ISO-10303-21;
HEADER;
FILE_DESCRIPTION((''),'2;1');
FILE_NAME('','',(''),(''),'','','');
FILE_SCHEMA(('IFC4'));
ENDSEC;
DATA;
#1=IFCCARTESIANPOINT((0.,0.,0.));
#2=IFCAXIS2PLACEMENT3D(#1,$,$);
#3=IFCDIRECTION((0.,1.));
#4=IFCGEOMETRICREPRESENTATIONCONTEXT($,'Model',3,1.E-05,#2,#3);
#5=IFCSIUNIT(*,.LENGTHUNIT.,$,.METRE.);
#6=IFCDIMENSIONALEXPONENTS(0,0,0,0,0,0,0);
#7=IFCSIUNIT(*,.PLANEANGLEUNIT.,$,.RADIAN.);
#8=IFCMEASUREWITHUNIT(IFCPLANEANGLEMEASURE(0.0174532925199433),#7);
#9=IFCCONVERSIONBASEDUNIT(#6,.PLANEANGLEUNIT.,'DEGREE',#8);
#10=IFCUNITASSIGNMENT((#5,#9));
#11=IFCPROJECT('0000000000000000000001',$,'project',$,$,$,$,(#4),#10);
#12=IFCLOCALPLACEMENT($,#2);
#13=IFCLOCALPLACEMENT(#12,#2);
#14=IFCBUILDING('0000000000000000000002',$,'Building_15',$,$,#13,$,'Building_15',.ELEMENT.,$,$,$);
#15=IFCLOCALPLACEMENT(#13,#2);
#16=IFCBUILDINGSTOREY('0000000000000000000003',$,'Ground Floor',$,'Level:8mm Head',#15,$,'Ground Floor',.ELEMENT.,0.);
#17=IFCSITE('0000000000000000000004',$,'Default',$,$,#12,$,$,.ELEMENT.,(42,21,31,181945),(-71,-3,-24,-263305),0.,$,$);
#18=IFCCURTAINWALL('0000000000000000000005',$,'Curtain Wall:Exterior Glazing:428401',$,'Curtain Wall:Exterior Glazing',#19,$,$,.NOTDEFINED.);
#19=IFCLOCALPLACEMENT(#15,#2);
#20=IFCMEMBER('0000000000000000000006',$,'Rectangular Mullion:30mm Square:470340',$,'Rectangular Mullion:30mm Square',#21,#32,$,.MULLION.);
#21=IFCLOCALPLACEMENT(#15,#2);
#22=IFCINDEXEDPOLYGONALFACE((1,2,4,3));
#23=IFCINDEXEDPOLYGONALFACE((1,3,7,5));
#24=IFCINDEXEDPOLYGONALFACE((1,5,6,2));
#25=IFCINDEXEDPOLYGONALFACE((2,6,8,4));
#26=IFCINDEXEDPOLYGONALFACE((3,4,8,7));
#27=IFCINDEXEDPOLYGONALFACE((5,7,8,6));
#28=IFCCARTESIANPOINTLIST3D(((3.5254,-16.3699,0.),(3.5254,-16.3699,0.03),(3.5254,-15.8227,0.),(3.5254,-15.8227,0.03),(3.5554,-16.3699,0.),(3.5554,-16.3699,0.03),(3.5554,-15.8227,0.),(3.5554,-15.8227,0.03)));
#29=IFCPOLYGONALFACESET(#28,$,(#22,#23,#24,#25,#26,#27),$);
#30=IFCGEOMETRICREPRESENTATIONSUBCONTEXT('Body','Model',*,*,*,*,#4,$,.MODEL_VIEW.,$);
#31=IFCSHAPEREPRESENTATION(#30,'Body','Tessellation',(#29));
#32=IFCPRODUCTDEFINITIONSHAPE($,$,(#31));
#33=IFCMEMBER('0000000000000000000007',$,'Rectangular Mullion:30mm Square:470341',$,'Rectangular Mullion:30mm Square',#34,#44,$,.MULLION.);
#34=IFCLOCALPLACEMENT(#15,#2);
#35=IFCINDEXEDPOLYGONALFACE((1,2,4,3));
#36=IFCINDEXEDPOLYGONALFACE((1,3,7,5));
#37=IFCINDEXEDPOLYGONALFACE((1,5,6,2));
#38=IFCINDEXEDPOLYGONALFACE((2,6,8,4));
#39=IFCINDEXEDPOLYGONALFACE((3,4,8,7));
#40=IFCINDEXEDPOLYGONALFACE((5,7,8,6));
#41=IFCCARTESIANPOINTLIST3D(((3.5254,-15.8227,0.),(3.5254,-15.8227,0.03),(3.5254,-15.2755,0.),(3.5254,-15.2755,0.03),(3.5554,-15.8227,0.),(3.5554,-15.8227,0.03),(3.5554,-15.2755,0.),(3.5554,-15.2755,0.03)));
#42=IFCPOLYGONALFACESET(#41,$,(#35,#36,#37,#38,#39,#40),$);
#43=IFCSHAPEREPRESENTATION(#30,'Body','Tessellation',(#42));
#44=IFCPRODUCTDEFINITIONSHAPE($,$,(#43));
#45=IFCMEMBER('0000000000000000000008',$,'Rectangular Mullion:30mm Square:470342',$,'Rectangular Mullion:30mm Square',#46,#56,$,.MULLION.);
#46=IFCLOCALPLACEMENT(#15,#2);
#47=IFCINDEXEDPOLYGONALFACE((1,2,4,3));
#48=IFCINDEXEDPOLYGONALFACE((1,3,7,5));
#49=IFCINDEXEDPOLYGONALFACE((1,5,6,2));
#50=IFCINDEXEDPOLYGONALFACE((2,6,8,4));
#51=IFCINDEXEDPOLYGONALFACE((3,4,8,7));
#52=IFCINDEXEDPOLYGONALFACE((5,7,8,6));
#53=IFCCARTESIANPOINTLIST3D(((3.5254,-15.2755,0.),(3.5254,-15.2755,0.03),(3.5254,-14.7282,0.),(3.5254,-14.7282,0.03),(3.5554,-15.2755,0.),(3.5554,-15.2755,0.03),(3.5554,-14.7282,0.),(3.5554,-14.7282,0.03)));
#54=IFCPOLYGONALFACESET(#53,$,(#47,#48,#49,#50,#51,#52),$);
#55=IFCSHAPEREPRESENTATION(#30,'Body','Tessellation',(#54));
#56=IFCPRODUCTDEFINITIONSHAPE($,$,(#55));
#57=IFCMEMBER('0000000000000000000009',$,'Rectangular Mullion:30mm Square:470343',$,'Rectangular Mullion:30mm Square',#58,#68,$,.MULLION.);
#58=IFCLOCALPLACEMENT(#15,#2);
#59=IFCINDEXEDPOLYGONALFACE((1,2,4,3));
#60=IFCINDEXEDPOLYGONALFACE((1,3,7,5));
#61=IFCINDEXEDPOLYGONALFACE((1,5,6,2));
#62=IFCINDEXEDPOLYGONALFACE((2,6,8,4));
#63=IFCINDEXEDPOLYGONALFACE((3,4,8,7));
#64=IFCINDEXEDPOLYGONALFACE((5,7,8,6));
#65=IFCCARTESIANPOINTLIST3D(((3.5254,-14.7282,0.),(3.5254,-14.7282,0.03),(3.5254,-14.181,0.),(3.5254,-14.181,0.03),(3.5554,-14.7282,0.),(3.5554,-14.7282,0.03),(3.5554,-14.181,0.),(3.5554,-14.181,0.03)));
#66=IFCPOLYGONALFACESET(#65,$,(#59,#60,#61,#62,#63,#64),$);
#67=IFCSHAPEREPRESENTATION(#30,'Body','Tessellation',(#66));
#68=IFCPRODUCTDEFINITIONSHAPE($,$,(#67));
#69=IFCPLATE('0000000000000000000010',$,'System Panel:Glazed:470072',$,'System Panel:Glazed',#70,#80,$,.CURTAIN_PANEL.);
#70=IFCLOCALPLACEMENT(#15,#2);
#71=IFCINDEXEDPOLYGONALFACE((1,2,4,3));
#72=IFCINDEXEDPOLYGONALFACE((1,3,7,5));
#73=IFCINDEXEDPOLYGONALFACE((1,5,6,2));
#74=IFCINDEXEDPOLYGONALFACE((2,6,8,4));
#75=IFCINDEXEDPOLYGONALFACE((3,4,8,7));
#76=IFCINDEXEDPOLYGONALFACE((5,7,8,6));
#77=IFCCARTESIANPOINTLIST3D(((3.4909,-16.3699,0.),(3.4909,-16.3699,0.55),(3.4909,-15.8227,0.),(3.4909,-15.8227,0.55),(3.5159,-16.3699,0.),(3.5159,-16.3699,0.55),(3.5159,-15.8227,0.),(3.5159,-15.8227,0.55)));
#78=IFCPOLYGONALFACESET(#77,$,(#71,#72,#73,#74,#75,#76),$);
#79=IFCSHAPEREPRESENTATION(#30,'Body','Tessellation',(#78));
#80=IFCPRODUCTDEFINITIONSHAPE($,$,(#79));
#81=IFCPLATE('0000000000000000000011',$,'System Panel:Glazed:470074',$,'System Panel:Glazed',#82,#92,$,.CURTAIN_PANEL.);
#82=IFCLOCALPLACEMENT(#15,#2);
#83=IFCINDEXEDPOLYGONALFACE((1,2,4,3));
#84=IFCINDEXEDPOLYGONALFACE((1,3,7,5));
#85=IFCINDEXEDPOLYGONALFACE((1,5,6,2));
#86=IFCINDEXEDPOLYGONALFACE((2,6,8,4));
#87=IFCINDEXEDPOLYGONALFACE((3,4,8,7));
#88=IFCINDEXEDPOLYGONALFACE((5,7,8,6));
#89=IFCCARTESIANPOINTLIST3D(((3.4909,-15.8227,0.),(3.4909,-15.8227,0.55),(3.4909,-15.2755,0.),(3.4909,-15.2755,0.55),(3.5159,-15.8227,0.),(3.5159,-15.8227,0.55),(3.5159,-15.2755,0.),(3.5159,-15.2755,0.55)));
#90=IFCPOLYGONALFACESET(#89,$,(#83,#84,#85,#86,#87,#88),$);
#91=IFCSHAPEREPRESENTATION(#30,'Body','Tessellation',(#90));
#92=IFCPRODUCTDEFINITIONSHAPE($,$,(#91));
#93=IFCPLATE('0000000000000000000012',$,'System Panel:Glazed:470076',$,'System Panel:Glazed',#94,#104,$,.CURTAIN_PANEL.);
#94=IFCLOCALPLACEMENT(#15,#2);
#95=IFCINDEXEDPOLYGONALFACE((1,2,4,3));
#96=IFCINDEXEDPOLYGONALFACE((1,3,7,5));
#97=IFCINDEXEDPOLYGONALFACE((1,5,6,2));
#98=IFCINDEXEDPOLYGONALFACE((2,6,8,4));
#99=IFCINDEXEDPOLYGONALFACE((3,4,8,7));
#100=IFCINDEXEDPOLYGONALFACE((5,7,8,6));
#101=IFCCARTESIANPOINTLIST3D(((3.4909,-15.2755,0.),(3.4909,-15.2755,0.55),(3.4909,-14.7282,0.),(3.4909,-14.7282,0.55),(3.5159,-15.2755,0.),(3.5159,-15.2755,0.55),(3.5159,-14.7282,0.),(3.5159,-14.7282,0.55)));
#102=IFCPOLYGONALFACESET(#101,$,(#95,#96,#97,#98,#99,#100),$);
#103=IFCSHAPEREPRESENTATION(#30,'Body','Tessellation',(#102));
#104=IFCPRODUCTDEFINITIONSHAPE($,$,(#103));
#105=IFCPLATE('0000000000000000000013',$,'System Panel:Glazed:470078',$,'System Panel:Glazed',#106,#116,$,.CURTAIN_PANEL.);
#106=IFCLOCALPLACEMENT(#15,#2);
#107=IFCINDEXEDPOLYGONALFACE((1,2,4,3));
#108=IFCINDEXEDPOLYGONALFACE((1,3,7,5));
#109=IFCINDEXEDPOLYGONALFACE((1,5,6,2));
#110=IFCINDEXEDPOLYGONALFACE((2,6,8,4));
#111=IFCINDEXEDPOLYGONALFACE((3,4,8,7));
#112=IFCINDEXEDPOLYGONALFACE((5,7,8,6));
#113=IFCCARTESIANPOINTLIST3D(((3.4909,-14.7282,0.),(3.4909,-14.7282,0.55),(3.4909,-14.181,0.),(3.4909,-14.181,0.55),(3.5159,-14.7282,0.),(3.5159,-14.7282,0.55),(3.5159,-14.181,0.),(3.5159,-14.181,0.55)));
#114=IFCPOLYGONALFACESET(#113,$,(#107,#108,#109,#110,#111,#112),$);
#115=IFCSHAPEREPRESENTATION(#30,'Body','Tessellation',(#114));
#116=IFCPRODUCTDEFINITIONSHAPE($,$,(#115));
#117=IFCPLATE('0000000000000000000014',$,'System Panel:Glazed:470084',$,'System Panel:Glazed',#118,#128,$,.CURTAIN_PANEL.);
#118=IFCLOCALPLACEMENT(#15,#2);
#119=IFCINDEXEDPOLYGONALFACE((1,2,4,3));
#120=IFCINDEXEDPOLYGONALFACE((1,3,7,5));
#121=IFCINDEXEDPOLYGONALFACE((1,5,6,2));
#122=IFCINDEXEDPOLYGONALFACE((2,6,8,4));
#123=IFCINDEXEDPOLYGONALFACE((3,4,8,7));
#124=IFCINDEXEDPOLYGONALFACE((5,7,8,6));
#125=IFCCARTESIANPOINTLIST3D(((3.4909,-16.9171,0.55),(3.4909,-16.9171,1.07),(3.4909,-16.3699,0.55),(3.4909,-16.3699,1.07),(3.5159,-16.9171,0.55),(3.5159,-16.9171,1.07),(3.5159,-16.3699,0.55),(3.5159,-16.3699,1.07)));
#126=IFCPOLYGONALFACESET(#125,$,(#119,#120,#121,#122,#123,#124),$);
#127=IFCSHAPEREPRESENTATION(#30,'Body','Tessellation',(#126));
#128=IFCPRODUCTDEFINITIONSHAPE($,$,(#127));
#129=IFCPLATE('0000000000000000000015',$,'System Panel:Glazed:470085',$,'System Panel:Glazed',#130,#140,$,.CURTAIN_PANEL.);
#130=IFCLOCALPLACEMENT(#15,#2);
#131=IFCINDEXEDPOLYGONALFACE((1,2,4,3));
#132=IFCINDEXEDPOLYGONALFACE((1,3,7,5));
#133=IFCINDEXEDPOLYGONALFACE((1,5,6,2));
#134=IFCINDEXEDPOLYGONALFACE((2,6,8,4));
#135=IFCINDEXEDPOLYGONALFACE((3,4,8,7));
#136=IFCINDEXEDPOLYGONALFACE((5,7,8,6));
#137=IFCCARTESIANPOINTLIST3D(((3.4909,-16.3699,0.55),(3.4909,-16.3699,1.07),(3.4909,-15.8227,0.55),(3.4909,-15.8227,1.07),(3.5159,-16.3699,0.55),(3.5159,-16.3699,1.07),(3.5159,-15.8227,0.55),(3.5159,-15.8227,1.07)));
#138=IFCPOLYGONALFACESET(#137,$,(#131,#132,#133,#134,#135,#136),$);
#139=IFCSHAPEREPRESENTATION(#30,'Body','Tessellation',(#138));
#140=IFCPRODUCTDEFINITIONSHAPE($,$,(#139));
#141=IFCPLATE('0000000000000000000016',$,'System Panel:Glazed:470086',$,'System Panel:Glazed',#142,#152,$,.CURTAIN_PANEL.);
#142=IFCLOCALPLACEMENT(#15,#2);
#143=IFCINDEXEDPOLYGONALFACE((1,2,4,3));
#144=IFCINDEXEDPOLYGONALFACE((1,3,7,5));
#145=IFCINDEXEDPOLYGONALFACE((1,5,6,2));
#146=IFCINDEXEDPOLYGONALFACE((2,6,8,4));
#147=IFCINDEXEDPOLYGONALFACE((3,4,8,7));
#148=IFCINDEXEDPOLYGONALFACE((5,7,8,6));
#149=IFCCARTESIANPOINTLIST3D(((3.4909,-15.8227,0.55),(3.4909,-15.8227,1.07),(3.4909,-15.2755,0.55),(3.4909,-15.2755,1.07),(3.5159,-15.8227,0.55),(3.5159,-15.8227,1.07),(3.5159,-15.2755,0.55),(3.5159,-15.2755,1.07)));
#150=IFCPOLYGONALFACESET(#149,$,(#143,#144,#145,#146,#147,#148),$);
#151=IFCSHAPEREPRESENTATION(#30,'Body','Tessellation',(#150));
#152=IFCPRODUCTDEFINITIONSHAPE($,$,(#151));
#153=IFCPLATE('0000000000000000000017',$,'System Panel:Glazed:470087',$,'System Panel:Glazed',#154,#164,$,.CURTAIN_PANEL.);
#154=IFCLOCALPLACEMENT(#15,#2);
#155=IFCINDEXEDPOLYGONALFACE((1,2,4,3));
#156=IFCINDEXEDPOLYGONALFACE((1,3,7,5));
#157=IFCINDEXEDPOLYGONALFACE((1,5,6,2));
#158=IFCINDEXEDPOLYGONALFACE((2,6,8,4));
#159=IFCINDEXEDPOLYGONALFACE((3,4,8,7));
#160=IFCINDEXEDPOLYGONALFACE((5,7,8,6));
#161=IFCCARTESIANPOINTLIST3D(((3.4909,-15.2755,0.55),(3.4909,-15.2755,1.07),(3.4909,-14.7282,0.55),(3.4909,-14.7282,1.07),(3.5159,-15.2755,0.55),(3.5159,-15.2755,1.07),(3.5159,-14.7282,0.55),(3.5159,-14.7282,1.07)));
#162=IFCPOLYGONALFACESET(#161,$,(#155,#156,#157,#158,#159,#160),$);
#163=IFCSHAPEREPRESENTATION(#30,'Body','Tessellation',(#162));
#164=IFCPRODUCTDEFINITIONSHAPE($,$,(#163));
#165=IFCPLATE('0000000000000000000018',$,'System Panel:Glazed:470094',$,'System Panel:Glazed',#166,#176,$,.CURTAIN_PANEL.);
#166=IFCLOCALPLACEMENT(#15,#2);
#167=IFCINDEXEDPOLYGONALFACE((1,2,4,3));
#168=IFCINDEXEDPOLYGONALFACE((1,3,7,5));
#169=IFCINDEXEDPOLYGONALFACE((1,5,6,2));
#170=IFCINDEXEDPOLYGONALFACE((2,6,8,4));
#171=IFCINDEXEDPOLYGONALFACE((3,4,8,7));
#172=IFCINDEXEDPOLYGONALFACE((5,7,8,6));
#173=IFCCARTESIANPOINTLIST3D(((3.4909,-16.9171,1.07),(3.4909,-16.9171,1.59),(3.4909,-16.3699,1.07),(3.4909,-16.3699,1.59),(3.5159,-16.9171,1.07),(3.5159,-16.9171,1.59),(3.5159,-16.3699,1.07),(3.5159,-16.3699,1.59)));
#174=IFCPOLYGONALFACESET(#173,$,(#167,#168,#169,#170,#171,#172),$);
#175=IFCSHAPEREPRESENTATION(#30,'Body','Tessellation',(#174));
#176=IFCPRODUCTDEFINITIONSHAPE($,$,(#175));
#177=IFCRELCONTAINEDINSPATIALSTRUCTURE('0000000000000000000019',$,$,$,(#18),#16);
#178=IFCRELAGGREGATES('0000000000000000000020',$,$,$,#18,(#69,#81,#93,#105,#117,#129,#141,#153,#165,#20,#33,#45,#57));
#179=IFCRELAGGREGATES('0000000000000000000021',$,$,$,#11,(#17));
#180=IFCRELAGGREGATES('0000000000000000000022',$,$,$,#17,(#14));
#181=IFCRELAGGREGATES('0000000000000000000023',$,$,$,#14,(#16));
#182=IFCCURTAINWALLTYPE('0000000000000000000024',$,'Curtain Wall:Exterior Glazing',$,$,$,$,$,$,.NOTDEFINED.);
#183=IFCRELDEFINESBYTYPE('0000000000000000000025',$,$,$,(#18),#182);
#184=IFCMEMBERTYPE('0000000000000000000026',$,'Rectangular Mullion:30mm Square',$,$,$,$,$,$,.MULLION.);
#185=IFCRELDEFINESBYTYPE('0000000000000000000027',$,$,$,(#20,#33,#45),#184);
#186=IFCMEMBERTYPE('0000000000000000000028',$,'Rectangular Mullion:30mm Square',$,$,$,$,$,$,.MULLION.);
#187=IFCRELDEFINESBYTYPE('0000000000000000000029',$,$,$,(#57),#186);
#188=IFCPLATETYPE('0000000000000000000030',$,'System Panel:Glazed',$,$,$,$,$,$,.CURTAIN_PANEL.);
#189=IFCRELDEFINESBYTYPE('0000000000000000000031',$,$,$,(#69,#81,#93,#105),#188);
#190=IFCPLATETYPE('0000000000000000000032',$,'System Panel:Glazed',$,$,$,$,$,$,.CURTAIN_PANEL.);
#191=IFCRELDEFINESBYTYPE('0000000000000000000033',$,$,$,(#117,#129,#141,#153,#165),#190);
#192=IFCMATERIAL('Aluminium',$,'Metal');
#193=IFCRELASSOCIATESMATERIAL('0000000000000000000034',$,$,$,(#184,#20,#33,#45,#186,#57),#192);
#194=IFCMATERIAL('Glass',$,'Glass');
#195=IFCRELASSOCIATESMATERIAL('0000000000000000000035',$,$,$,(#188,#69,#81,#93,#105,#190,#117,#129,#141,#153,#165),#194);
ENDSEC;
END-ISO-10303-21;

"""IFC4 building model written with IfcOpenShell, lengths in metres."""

from ifc_helpers import new_model, entity, si_unit, converted_unit, direction, frame, origin, place, context, subcontext, project, spatial, indexed_curve, outline, extrude, source, transform, mapped, material, type_object, type_shapes, element, aggregate, save


model = new_model("IFC4")

# Units and contexts
model_context = context("Model", 3, precision=1e-05, world=origin(), true_north=direction((0.0, 1.0)))
body_context = subcontext(model_context, "Body", "Model", "MODEL_VIEW")
ifc_project = project(units=[si_unit("LENGTHUNIT", "METRE"), converted_unit("PLANEANGLEUNIT", "DEGREE", entity("IfcPlaneAngleMeasure", 0.0174532925199433), si_unit("PLANEANGLEUNIT", "RADIAN"), dimensions=[0, 0, 0, 0, 0, 0, 0])], contexts=[model_context])

# Site, building, storey
site_placement = place(None, origin())
site = spatial("IfcSite", under=ifc_project, at=site_placement, Name="Default", CompositionType="ELEMENT", RefLatitude=(42, 21, 31, 181945), RefLongitude=(-71, -3, -24, -263305), RefElevation=0.0)
building_placement = place(site_placement, origin())
building = spatial("IfcBuilding", under=site, at=building_placement, Name="Building_15", LongName="Building_15", CompositionType="ELEMENT")
storey_placement = place(building_placement, origin())
storey = spatial("IfcBuildingStorey", under=building, at=storey_placement, Name="Ground Floor", ObjectType="Level:8mm Head", LongName="Ground Floor", CompositionType="ELEMENT", Elevation=0.0)

# Curtain wall, members, plates
curtain_wall_type = type_object("IfcCurtainWallType", Name="Curtain Wall:Exterior Glazing", PredefinedType="NOTDEFINED")
curtain_wall_placement = place(storey_placement, origin())
curtain_wall = element("IfcCurtainWall", 1, at=curtain_wall_placement, inside=storey, type_object=curtain_wall_type, Name="Curtain Wall:Exterior Glazing:428401", ObjectType="Curtain Wall:Exterior Glazing", PredefinedType="NOTDEFINED")
ifc_material_1 = material(Name="Aluminium", Category="Metal")
member_type_1 = type_object("IfcMemberType", Name="Rectangular Mullion:30mm Square", PredefinedType="MULLION", material=ifc_material_1)
shared_shape_1 = source(origin(), body_context, "Body", "SweptSolid", [
    extrude(outline(indexed_curve([(-0.015, -0.015), (0.015, -0.015), (0.015, 0.015), (-0.015, 0.015), (-0.015, -0.015)], self_intersect=False)), frame((-0.015, 0.0, -0.5472), z_axis=(0.0, 0.0, 1.0), x_axis=(-1.0, 0.0, 0.0)), (0.0, 0.0, 1.0), 0.5472),
])
type_shapes(member_type_1, [shared_shape_1])
member_1_placement = place(curtain_wall_placement, frame((3.5404, -16.3699, 0.0), z_axis=(0.0, -1.0, 0.0), x_axis=(0.0, 0.0, -1.0)))
member_1 = element("IfcMember", 2, at=member_1_placement, type_object=member_type_1, material=ifc_material_1, Name="Rectangular Mullion:30mm Square:470340", ObjectType="Rectangular Mullion:30mm Square", PredefinedType="MULLION", context=body_context, shape_type="MappedRepresentation", body=[
    mapped(shared_shape_1, transform((0.0, 0.0, 0.0), scale=1.0)),
])
member_2_placement = place(curtain_wall_placement, frame((3.5404, -15.8227, 0.0), z_axis=(0.0, -1.0, 0.0), x_axis=(0.0, 0.0, -1.0)))
member_2 = element("IfcMember", 3, at=member_2_placement, type_object=member_type_1, material=ifc_material_1, Name="Rectangular Mullion:30mm Square:470341", ObjectType="Rectangular Mullion:30mm Square", PredefinedType="MULLION", context=body_context, shape_type="MappedRepresentation", body=[
    mapped(shared_shape_1, transform((0.0, 0.0, 0.0), scale=1.0)),
])
member_3_placement = place(curtain_wall_placement, frame((3.5404, -15.2755, 0.0), z_axis=(0.0, -1.0, 0.0), x_axis=(0.0, 0.0, -1.0)))
member_3 = element("IfcMember", 4, at=member_3_placement, type_object=member_type_1, material=ifc_material_1, Name="Rectangular Mullion:30mm Square:470342", ObjectType="Rectangular Mullion:30mm Square", PredefinedType="MULLION", context=body_context, shape_type="MappedRepresentation", body=[
    mapped(shared_shape_1, transform((0.0, 0.0, 0.0), scale=1.0)),
])
member_type_2 = type_object("IfcMemberType", Name="Rectangular Mullion:30mm Square", PredefinedType="MULLION", material=ifc_material_1)
shared_shape_2 = source(origin(), body_context, "Body", "SweptSolid", [
    extrude(outline(indexed_curve([(-0.015, -0.015), (0.015, -0.015), (0.015, 0.015), (-0.015, 0.015), (-0.015, -0.015)], self_intersect=False)), frame((-0.015, 0.0, -0.5472), z_axis=(0.0, 0.0, 1.0), x_axis=(-1.0, 0.0, 0.0)), (0.0, 0.0, 1.0), 0.5472),
])
type_shapes(member_type_2, [shared_shape_2])
member_4_placement = place(curtain_wall_placement, frame((3.5404, -14.7282, 0.0), z_axis=(0.0, -1.0, 0.0), x_axis=(0.0, 0.0, -1.0)))
member_4 = element("IfcMember", 5, at=member_4_placement, type_object=member_type_2, material=ifc_material_1, Name="Rectangular Mullion:30mm Square:470343", ObjectType="Rectangular Mullion:30mm Square", PredefinedType="MULLION", context=body_context, shape_type="MappedRepresentation", body=[
    mapped(shared_shape_2, transform((0.0, 0.0, 0.0), scale=1.0)),
])
ifc_material_2 = material(Name="Glass", Category="Glass")
plate_type_1 = type_object("IfcPlateType", Name="System Panel:Glazed", PredefinedType="CURTAIN_PANEL", material=ifc_material_2)
shared_shape_3 = source(origin(), body_context, "Body", "SweptSolid", [
    extrude(outline(indexed_curve([(-0.0125, -0.2736), (0.0125, -0.2736), (0.0125, 0.2736), (-0.0125, 0.2736), (-0.0125, -0.2736)], self_intersect=False)), frame((0.0, 0.037, 0.0), z_axis=(0.0, 0.0, 1.0), x_axis=(0.0, 1.0, 0.0)), (0.0, 0.0, 1.0), 0.55),
])
type_shapes(plate_type_1, [shared_shape_3])
plate_1_placement = place(curtain_wall_placement, frame((3.5404, -16.0963, 0.0), z_axis=(0.0, 0.0, 1.0), x_axis=(0.0, 1.0, 0.0)))
plate_1 = element("IfcPlate", 6, at=plate_1_placement, type_object=plate_type_1, material=ifc_material_2, Name="System Panel:Glazed:470072", ObjectType="System Panel:Glazed", PredefinedType="CURTAIN_PANEL", context=body_context, shape_type="MappedRepresentation", body=[
    mapped(shared_shape_3, transform((0.0, 0.0, 0.0), scale=1.0)),
])
plate_2_placement = place(curtain_wall_placement, frame((3.5404, -15.5491, 0.0), z_axis=(0.0, 0.0, 1.0), x_axis=(0.0, 1.0, 0.0)))
plate_2 = element("IfcPlate", 7, at=plate_2_placement, type_object=plate_type_1, material=ifc_material_2, Name="System Panel:Glazed:470074", ObjectType="System Panel:Glazed", PredefinedType="CURTAIN_PANEL", context=body_context, shape_type="MappedRepresentation", body=[
    mapped(shared_shape_3, transform((0.0, 0.0, 0.0), scale=1.0)),
])
plate_3_placement = place(curtain_wall_placement, frame((3.5404, -15.0018, 0.0), z_axis=(0.0, 0.0, 1.0), x_axis=(0.0, 1.0, 0.0)))
plate_3 = element("IfcPlate", 8, at=plate_3_placement, type_object=plate_type_1, material=ifc_material_2, Name="System Panel:Glazed:470076", ObjectType="System Panel:Glazed", PredefinedType="CURTAIN_PANEL", context=body_context, shape_type="MappedRepresentation", body=[
    mapped(shared_shape_3, transform((0.0, 0.0, 0.0), scale=1.0)),
])
plate_4_placement = place(curtain_wall_placement, frame((3.5404, -14.4546, 0.0), z_axis=(0.0, 0.0, 1.0), x_axis=(0.0, 1.0, 0.0)))
plate_4 = element("IfcPlate", 9, at=plate_4_placement, type_object=plate_type_1, material=ifc_material_2, Name="System Panel:Glazed:470078", ObjectType="System Panel:Glazed", PredefinedType="CURTAIN_PANEL", context=body_context, shape_type="MappedRepresentation", body=[
    mapped(shared_shape_3, transform((0.0, 0.0, 0.0), scale=1.0)),
])
plate_type_2 = type_object("IfcPlateType", Name="System Panel:Glazed", PredefinedType="CURTAIN_PANEL", material=ifc_material_2)
shared_shape_4 = source(origin(), body_context, "Body", "SweptSolid", [
    extrude(outline(indexed_curve([(-0.0125, -0.2736), (0.0125, -0.2736), (0.0125, 0.2736), (-0.0125, 0.2736), (-0.0125, -0.2736)], self_intersect=False)), frame((0.0, 0.037, 0.0), z_axis=(0.0, 0.0, 1.0), x_axis=(0.0, 1.0, 0.0)), (0.0, 0.0, 1.0), 0.52),
])
type_shapes(plate_type_2, [shared_shape_4])
plate_5_placement = place(curtain_wall_placement, frame((3.5404, -16.6435, 0.55), z_axis=(0.0, 0.0, 1.0), x_axis=(0.0, 1.0, 0.0)))
plate_5 = element("IfcPlate", 10, at=plate_5_placement, type_object=plate_type_2, material=ifc_material_2, Name="System Panel:Glazed:470084", ObjectType="System Panel:Glazed", PredefinedType="CURTAIN_PANEL", context=body_context, shape_type="MappedRepresentation", body=[
    mapped(shared_shape_4, transform((0.0, 0.0, 0.0), scale=1.0)),
])
plate_6_placement = place(curtain_wall_placement, frame((3.5404, -16.0963, 0.55), z_axis=(0.0, 0.0, 1.0), x_axis=(0.0, 1.0, 0.0)))
plate_6 = element("IfcPlate", 11, at=plate_6_placement, type_object=plate_type_2, material=ifc_material_2, Name="System Panel:Glazed:470085", ObjectType="System Panel:Glazed", PredefinedType="CURTAIN_PANEL", context=body_context, shape_type="MappedRepresentation", body=[
    mapped(shared_shape_4, transform((0.0, 0.0, 0.0), scale=1.0)),
])
plate_7_placement = place(curtain_wall_placement, frame((3.5404, -15.5491, 0.55), z_axis=(0.0, 0.0, 1.0), x_axis=(0.0, 1.0, 0.0)))
plate_7 = element("IfcPlate", 12, at=plate_7_placement, type_object=plate_type_2, material=ifc_material_2, Name="System Panel:Glazed:470086", ObjectType="System Panel:Glazed", PredefinedType="CURTAIN_PANEL", context=body_context, shape_type="MappedRepresentation", body=[
    mapped(shared_shape_4, transform((0.0, 0.0, 0.0), scale=1.0)),
])
plate_8_placement = place(curtain_wall_placement, frame((3.5404, -15.0018, 0.55), z_axis=(0.0, 0.0, 1.0), x_axis=(0.0, 1.0, 0.0)))
plate_8 = element("IfcPlate", 13, at=plate_8_placement, type_object=plate_type_2, material=ifc_material_2, Name="System Panel:Glazed:470087", ObjectType="System Panel:Glazed", PredefinedType="CURTAIN_PANEL", context=body_context, shape_type="MappedRepresentation", body=[
    mapped(shared_shape_4, transform((0.0, 0.0, 0.0), scale=1.0)),
])
plate_9_placement = place(curtain_wall_placement, frame((3.5404, -16.6435, 1.07), z_axis=(0.0, 0.0, 1.0), x_axis=(0.0, 1.0, 0.0)))
plate_9 = element("IfcPlate", 14, at=plate_9_placement, type_object=plate_type_2, material=ifc_material_2, Name="System Panel:Glazed:470094", ObjectType="System Panel:Glazed", PredefinedType="CURTAIN_PANEL", context=body_context, shape_type="MappedRepresentation", body=[
    mapped(shared_shape_4, transform((0.0, 0.0, 0.0), scale=1.0)),
])
aggregate(curtain_wall, [plate_1, plate_2, plate_3, plate_4, plate_5, plate_6, plate_7, plate_8, plate_9, member_1, member_2, member_3, member_4])

save(model, "model.ifc")
